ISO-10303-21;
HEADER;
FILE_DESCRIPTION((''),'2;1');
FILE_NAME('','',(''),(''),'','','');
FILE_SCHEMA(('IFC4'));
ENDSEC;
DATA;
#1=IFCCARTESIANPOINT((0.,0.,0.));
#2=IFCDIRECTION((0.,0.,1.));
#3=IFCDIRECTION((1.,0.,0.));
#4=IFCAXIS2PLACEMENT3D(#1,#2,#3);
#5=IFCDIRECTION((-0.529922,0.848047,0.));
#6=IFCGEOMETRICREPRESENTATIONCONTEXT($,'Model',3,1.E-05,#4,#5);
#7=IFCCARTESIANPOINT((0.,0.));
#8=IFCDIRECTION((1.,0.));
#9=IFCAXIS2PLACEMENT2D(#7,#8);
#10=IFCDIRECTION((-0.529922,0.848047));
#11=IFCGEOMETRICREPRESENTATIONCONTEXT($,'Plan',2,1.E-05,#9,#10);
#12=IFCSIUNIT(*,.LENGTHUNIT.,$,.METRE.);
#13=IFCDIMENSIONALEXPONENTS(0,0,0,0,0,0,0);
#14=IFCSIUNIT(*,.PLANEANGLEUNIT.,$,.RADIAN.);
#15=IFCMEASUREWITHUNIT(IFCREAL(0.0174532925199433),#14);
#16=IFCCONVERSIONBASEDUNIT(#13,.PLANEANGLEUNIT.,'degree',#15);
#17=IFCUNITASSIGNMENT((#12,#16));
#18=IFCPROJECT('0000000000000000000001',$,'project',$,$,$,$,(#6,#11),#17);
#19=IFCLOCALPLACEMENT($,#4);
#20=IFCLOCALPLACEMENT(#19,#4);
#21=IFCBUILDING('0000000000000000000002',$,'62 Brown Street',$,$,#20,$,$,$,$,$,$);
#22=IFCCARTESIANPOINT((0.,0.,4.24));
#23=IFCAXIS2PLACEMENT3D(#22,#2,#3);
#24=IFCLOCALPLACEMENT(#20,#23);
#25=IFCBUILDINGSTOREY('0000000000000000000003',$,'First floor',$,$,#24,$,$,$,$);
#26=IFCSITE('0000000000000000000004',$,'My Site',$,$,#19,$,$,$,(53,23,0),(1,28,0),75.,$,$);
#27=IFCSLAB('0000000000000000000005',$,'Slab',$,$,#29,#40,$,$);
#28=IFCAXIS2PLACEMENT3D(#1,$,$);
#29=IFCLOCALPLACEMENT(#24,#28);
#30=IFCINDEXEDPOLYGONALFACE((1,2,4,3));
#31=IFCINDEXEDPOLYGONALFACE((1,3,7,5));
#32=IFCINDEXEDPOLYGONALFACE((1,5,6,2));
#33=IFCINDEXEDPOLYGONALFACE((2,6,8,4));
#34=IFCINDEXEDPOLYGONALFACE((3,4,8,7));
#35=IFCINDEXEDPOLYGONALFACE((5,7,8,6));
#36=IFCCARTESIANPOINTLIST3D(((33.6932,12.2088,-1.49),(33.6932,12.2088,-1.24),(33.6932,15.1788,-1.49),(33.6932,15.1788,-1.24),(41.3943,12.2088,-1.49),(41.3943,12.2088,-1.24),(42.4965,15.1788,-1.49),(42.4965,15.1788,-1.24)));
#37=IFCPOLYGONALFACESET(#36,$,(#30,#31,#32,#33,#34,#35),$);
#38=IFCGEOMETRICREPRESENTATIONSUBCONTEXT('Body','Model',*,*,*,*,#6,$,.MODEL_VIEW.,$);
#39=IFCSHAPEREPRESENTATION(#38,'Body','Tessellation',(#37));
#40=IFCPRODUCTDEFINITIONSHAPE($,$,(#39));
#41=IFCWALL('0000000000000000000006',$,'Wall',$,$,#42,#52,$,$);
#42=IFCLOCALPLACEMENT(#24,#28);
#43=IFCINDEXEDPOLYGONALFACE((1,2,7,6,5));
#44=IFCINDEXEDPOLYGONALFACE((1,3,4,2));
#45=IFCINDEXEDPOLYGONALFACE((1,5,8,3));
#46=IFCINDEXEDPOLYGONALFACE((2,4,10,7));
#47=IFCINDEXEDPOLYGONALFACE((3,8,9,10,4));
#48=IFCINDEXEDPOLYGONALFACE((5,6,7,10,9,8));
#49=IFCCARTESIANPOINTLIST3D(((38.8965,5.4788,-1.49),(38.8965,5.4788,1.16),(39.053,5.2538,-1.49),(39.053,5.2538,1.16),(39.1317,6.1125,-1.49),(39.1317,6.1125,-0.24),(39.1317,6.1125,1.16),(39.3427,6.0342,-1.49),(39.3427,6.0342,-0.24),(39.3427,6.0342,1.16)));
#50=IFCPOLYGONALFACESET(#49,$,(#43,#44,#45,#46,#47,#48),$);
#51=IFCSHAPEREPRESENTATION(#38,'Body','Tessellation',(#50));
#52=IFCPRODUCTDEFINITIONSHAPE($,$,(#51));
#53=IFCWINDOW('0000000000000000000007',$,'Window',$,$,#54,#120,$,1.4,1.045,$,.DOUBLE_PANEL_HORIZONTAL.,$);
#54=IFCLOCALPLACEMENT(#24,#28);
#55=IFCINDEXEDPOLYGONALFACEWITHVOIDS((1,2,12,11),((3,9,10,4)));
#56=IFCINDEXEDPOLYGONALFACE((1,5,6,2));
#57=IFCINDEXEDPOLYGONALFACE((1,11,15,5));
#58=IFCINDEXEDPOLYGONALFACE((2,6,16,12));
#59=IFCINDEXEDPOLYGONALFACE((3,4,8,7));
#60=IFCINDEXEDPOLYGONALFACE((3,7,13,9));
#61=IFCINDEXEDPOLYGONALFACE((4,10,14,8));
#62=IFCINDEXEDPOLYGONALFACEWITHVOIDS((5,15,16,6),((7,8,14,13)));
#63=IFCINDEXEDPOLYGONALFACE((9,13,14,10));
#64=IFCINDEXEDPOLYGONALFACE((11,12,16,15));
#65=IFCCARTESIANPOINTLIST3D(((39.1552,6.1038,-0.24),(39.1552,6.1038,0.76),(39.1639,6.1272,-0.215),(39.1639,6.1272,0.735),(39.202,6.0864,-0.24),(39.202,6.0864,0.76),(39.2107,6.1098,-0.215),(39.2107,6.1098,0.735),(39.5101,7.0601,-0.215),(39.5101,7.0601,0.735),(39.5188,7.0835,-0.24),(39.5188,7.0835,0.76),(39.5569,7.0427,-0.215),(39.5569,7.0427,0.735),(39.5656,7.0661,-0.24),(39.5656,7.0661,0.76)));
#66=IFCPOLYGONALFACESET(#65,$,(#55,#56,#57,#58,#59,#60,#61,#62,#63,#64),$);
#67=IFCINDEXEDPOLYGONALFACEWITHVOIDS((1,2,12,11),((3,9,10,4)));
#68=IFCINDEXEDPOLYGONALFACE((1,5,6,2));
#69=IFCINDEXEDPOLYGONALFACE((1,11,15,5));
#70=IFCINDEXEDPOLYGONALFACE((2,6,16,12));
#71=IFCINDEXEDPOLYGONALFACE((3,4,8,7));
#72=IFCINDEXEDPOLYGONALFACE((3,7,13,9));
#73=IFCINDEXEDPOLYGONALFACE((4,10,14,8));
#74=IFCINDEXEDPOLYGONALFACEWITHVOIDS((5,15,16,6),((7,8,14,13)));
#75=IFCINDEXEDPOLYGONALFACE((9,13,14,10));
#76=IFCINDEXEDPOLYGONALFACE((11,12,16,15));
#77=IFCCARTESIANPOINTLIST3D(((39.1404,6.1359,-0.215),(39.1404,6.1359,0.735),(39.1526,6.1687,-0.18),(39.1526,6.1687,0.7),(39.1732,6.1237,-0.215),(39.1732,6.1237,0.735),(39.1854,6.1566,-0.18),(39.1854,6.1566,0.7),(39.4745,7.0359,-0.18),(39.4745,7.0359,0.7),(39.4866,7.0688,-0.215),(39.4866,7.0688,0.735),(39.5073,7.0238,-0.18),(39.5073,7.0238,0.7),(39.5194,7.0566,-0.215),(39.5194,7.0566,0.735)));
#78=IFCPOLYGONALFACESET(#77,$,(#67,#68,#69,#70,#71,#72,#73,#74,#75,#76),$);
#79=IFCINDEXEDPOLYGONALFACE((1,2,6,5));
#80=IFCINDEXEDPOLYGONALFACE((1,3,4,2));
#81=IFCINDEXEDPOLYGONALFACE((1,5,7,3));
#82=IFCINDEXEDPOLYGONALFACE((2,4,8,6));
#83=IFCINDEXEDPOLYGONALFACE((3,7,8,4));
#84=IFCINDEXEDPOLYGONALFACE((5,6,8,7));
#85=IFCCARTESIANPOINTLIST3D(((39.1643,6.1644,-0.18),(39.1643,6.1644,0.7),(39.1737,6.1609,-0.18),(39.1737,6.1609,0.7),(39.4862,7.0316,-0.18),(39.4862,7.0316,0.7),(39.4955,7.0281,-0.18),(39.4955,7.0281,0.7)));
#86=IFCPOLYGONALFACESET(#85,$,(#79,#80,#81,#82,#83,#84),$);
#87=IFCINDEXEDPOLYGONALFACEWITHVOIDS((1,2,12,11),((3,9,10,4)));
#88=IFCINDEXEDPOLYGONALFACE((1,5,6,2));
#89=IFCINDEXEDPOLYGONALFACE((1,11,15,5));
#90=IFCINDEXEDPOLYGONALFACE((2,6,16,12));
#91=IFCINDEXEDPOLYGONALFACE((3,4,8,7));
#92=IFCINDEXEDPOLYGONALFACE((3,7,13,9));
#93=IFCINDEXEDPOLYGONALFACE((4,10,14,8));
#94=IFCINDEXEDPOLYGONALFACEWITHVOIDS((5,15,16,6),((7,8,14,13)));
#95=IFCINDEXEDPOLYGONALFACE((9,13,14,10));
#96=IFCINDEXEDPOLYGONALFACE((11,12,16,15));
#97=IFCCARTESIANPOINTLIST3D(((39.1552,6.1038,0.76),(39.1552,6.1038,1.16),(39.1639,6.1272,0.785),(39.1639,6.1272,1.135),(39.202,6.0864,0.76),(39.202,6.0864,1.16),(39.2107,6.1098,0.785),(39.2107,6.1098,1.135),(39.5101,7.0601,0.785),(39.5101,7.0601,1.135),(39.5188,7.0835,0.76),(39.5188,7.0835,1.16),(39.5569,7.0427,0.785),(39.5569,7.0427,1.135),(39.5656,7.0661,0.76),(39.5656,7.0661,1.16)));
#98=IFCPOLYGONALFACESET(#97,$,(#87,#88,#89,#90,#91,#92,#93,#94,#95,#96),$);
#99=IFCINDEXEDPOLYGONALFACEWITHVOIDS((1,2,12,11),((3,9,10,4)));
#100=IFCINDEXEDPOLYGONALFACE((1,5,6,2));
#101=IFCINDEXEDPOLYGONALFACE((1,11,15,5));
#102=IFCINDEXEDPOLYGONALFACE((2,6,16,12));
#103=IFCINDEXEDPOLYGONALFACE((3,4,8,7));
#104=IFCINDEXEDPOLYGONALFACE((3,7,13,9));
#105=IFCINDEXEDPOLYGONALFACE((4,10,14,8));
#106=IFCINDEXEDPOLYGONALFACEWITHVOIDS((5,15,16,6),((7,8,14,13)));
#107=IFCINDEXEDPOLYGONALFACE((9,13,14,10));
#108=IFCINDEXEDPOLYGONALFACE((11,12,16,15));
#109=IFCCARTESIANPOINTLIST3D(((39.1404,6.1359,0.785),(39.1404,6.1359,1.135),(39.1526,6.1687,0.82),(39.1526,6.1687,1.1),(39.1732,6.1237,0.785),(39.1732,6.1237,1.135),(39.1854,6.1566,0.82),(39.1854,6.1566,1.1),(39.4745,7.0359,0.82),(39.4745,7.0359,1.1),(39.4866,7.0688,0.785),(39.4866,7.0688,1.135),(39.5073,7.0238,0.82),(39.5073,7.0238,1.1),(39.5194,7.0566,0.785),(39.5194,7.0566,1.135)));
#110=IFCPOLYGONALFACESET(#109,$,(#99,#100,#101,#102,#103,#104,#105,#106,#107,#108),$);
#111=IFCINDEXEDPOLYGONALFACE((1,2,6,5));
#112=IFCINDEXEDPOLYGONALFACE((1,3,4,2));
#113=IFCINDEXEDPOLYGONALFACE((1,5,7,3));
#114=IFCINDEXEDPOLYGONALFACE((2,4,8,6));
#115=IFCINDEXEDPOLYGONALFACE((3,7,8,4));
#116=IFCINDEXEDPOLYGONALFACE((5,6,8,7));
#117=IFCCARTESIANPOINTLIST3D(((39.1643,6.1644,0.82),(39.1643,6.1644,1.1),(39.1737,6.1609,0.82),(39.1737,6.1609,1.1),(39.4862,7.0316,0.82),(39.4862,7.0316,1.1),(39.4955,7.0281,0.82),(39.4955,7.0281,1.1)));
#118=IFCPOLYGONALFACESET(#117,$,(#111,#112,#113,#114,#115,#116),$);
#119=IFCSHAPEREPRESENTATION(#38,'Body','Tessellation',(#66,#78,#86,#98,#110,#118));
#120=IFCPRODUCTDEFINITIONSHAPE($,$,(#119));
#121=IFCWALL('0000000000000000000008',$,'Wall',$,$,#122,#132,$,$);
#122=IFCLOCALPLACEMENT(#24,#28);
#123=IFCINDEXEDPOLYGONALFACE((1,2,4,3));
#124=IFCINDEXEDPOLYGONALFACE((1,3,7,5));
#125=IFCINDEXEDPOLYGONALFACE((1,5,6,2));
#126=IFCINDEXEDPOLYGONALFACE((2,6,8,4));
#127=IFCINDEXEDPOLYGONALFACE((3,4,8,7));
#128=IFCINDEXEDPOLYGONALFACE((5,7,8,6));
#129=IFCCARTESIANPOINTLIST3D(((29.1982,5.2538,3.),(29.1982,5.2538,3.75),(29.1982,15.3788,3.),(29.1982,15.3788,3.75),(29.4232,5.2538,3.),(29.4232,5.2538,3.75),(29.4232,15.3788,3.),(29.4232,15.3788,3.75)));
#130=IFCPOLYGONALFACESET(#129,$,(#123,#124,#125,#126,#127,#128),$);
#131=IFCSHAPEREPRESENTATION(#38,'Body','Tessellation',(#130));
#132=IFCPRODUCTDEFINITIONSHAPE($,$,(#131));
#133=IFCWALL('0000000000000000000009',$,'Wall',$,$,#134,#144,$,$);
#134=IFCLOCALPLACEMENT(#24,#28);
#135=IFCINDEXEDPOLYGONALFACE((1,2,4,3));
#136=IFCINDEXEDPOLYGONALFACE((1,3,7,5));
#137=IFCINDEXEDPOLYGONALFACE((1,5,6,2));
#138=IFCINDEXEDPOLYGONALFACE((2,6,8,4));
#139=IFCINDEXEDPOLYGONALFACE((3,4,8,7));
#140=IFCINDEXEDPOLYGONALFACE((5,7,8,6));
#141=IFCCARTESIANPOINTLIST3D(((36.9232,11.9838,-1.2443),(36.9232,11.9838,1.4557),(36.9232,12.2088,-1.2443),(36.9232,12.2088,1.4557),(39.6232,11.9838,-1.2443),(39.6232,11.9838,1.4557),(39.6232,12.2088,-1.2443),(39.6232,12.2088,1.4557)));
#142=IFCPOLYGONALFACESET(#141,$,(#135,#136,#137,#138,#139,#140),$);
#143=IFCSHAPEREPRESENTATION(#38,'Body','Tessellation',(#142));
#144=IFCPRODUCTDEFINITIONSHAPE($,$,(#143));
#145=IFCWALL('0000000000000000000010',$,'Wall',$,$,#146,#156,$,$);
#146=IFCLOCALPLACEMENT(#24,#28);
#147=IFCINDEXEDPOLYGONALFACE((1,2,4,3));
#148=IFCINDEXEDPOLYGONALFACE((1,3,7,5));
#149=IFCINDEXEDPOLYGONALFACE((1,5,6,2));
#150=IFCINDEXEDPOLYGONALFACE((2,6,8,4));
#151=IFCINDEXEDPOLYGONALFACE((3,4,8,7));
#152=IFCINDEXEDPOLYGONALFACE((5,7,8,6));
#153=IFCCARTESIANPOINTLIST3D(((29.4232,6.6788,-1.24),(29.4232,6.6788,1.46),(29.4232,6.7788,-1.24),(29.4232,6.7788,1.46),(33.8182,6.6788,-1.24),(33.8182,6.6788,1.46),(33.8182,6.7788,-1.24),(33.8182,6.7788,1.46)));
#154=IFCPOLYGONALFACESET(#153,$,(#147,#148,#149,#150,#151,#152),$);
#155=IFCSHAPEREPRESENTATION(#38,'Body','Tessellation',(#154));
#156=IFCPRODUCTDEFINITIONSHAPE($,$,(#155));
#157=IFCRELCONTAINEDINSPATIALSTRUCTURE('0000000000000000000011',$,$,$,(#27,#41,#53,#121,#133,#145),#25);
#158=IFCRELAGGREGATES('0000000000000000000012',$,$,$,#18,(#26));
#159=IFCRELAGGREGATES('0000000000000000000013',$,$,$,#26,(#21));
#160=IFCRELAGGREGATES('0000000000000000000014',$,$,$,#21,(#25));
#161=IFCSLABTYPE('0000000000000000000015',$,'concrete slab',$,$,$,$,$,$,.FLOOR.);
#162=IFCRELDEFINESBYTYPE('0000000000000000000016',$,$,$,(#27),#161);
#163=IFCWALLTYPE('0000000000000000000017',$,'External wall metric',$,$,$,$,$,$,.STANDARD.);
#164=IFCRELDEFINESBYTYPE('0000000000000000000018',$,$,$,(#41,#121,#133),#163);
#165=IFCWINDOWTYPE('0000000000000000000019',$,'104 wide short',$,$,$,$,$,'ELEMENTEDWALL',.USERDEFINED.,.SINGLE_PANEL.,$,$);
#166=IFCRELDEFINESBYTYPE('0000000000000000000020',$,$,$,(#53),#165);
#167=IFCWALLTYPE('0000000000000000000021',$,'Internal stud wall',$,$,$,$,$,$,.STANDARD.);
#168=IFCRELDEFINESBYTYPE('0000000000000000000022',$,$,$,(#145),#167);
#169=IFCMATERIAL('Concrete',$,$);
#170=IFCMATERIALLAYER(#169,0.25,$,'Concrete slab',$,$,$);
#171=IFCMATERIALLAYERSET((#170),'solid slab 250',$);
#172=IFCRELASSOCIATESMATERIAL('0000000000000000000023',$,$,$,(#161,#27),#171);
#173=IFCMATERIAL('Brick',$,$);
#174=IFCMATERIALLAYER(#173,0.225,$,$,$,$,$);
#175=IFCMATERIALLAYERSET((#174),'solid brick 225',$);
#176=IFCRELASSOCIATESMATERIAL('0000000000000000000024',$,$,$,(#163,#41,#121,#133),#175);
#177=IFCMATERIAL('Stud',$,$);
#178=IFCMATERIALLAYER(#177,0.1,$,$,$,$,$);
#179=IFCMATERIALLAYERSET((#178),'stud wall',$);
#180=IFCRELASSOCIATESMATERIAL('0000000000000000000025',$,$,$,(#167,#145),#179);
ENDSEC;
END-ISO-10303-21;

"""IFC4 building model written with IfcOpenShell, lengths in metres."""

from ifc_helpers import new_model, entity, si_unit, converted_unit, direction, frame, origin_with_axes, origin_2d_with_axis, place, context, subcontext, project, spatial, line, indexed_curve, outline, extrude, clip, halfspace, shape, source, transform, mapped, material, layer, layer_set, layer_usage, type_object, type_shapes, element, fill, save


model = new_model("IFC4")

# Units and contexts
model_context = context("Model", 3, precision=1e-05, world=origin_with_axes(), true_north=direction((-0.529922, 0.848047, 0.0)))
plan_context = context("Plan", 2, precision=1e-05, world=origin_2d_with_axis(), true_north=direction((-0.529922, 0.848047)))
body_context_1 = subcontext(model_context, "Body", "Model", "MODEL_VIEW")
body_context_2 = subcontext(plan_context, "Body", "Plan", "PLAN_VIEW")
ifc_project = project(units=[si_unit("LENGTHUNIT", "METRE"), converted_unit("PLANEANGLEUNIT", "degree", entity("IfcReal", 0.0174532925199433), si_unit("PLANEANGLEUNIT", "RADIAN"), dimensions=[0, 0, 0, 0, 0, 0, 0])], contexts=[model_context, plan_context])

# Site, building, storey
site_placement = place(None, origin_with_axes())
site = spatial("IfcSite", under=ifc_project, at=site_placement, Name="My Site", RefLatitude=(53, 23, 0), RefLongitude=(1, 28, 0), RefElevation=75.0)
building_placement = place(site_placement, origin_with_axes())
building = spatial("IfcBuilding", under=site, at=building_placement, Name="62 Brown Street")
storey_placement = place(building_placement, frame((0.0, 0.0, 4.24), z_axis=(0.0, 0.0, 1.0), x_axis=(1.0, 0.0, 0.0)))
storey = spatial("IfcBuildingStorey", under=building, at=storey_placement, Name="First floor")

# Slab
ifc_material_1 = material(Name="Concrete")
ifc_layer_1 = layer(ifc_material_1, 0.25, Name="Concrete slab")
ifc_layer_set_1 = layer_set([ifc_layer_1], Name="solid slab 250")
ifc_layer_usage_1 = layer_usage(ifc_layer_set_1, "AXIS3", "POSITIVE", 0.0)
slab_type = type_object("IfcSlabType", Name="concrete slab", PredefinedType="FLOOR", material=ifc_layer_set_1)
slab_placement = place(storey_placement, frame((33.6932, 12.2088, -1.49), z_axis=(0.0, 0.0, 1.0), x_axis=(1.0, 0.0, 0.0)))
element("IfcSlab", 1, at=slab_placement, inside=storey, type_object=slab_type, material=ifc_layer_usage_1, Name="Slab", context=body_context_1, shape_type="SweptSolid", body=[
    extrude(outline(indexed_curve([(8.8033, 2.97), (7.7011, 0.0), (0.0, 0.0), (0.0, 2.97)], segments=[line(4, 1), line(1, 2), line(2, 3), line(3, 4)], self_intersect=False)), None, (0.0, 0.0, 1.0), 0.25),
])

# Shared definitions
ifc_material_2 = material(Name="Brick")
ifc_layer_2 = layer(ifc_material_2, 0.225)
ifc_layer_set_2 = layer_set([ifc_layer_2], Name="solid brick 225")
wall_type_1 = type_object("IfcWallType", Name="External wall metric", PredefinedType="STANDARD", material=ifc_layer_set_2)

# Wall, opening, window
ifc_layer_usage_2 = layer_usage(ifc_layer_set_2, "AXIS2", "POSITIVE", 0.0)
wall_1_placement = place(storey_placement, frame((39.024, 5.1755, -1.49), z_axis=(0.0, 0.0, 1.0), x_axis=(0.347944, 0.937515, 0.0)))
wall_1 = element("IfcWall", 2, at=wall_1_placement, inside=storey, type_object=wall_type_1, material=ifc_layer_usage_2, Name="Wall", context=body_context_1, shape_type="Clipping", body=[
    clip(extrude(outline(indexed_curve([(0.0, 0.0), (0.0, 0.225), (0.9159, 0.225), (0.9159, 0.0), (0.0, 0.0)], self_intersect=False)), origin_with_axes(), (0.0, 0.0, 1.0), 2.65), halfspace(frame((0.0835, 0.0, -2.75), z_axis=(-0.596248, 0.414701, 0.0), x_axis=(0.156491, 0.224999, 0.0)), False)),
])
shared_shape_1 = source(origin_with_axes(), body_context_1, "Body", "SweptSolid", [
    extrude(outline(indexed_curve([(0.0, 0.0), (1.045, 0.0), (1.045, 1.4), (0.0, 1.4)], segments=[line(1, 2, 3, 4, 1)])), frame((0.0, -0.1, 0.0), z_axis=(0.0, -1.0, 0.0), x_axis=(1.0, 0.0, 0.0)), (0.0, 0.0, -1.0), 0.425),
])
opening_1_placement = place(wall_1_placement, frame((0.9159, 0.0, 1.25), z_axis=(0.0, 0.0, 1.0), x_axis=(1.0, 0.0, 0.0)))
opening_1 = element("IfcOpeningElement", 3, at=opening_1_placement, cuts=wall_1, PredefinedType="OPENING", context=body_context_1, shape_type="MappedRepresentation", body=[
    mapped(shared_shape_1, transform((0.0, 0.0, 0.0), x_axis=(1.0, 0.0, 0.0), y_axis=(0.0, 1.0, 0.0), z_axis=(0.0, 0.0, 1.0), scale=1.0)),
])
window_type_1 = type_object("IfcWindowType", Name="104 wide short", ElementType="ELEMENTEDWALL", PartitioningType="SINGLE_PANEL", PredefinedType="USERDEFINED")
shared_shape_2 = source(origin_with_axes(), body_context_1, "Body", "SweptSolid", [
    extrude(outline(indexed_curve([(0.0, 0.0), (1.045, 0.0), (1.045, 1.0), (0.0, 1.0)], segments=[line(1, 2, 3, 4, 1)]), holes=[indexed_curve([(0.025, 0.025), (1.02, 0.025), (1.02, 0.975), (0.025, 0.975)], segments=[line(1, 2, 3, 4, 1)])]), frame((0.0, 0.15, 0.0), z_axis=(0.0, -1.0, 0.0), x_axis=(1.0, 0.0, 0.0)), (0.0, 0.0, -1.0), 0.05),
    extrude(outline(indexed_curve([(0.0, 0.0), (0.995, 0.0), (0.995, 0.95), (0.0, 0.95)], segments=[line(1, 2, 3, 4, 1)]), holes=[indexed_curve([(0.035, 0.035), (0.96, 0.035), (0.96, 0.915), (0.035, 0.915)], segments=[line(1, 2, 3, 4, 1)])]), frame((0.025, 0.19, 0.025), z_axis=(0.0, -1.0, 0.0), x_axis=(1.0, 0.0, 0.0)), (0.0, 0.0, -1.0), 0.035),
    extrude(outline(indexed_curve([(0.035, 0.035), (0.96, 0.035), (0.96, 0.915), (0.035, 0.915)], segments=[line(1, 2, 3, 4, 1)])), frame((0.025, 0.2025, 0.025), z_axis=(0.0, -1.0, 0.0), x_axis=(1.0, 0.0, 0.0)), (0.0, 0.0, -1.0), 0.01),
    extrude(outline(indexed_curve([(0.0, 0.0), (1.045, 0.0), (1.045, 0.4), (0.0, 0.4)], segments=[line(1, 2, 3, 4, 1)]), holes=[indexed_curve([(0.025, 0.025), (1.02, 0.025), (1.02, 0.375), (0.025, 0.375)], segments=[line(1, 2, 3, 4, 1)])]), frame((0.0, 0.15, 1.0), z_axis=(0.0, -1.0, 0.0), x_axis=(1.0, 0.0, 0.0)), (0.0, 0.0, -1.0), 0.05),
    extrude(outline(indexed_curve([(0.0, 0.0), (0.995, 0.0), (0.995, 0.35), (0.0, 0.35)], segments=[line(1, 2, 3, 4, 1)]), holes=[indexed_curve([(0.035, 0.035), (0.96, 0.035), (0.96, 0.315), (0.035, 0.315)], segments=[line(1, 2, 3, 4, 1)])]), frame((0.025, 0.19, 1.025), z_axis=(0.0, -1.0, 0.0), x_axis=(1.0, 0.0, 0.0)), (0.0, 0.0, -1.0), 0.035),
    extrude(outline(indexed_curve([(0.035, 0.035), (0.96, 0.035), (0.96, 0.315), (0.035, 0.315)], segments=[line(1, 2, 3, 4, 1)])), frame((0.025, 0.2025, 1.025), z_axis=(0.0, -1.0, 0.0), x_axis=(1.0, 0.0, 0.0)), (0.0, 0.0, -1.0), 0.01),
])
shared_shape_3 = source(origin_with_axes(), body_context_2, "Body", "Curve2D", [
    entity("IfcIndexedPolyCurve", entity("IfcCartesianPointList2D", [[0.025, 0.15], [1.02, 0.15]])),
    entity("IfcIndexedPolyCurve", entity("IfcCartesianPointList2D", [[0.0, 0.2], [0.025, 0.2], [0.025, 0.15], [0.0, 0.15]]), [entity("IfcLineIndex", [1, 2, 3, 4, 1])]),
    entity("IfcIndexedPolyCurve", entity("IfcCartesianPointList2D", [[1.045, 0.2], [1.02, 0.2], [1.02, 0.15], [1.045, 0.15]]), [entity("IfcLineIndex", [1, 2, 3, 4, 1])]),
    entity("IfcIndexedPolyCurve", entity("IfcCartesianPointList2D", [[0.025, 0.19], [0.06, 0.19], [0.06, 0.225], [0.025, 0.225]]), [entity("IfcLineIndex", [1, 2, 3, 4, 1])]),
    entity("IfcIndexedPolyCurve", entity("IfcCartesianPointList2D", [[1.02, 0.19], [0.985, 0.19], [0.985, 0.225], [1.02, 0.225]]), [entity("IfcLineIndex", [1, 2, 3, 4, 1])]),
    entity("IfcIndexedPolyCurve", entity("IfcCartesianPointList2D", [[0.06, 0.19], [0.985, 0.19]])),
    entity("IfcIndexedPolyCurve", entity("IfcCartesianPointList2D", [[0.06, 0.225], [0.985, 0.225]])),
    entity("IfcIndexedPolyCurve", entity("IfcCartesianPointList2D", [[0.06, 0.2075], [0.985, 0.2075]])),
])
type_shapes(window_type_1, [shared_shape_2, shared_shape_3])
window_1_placement = place(opening_1_placement, frame((0.0, 0.0, 0.0), z_axis=(0.0, 0.0, 1.0), x_axis=(1.0, 0.0, 0.0)))
window_1 = element("IfcWindow", 4, at=window_1_placement, inside=storey, type_object=window_type_1, Name="Window", OverallHeight=1.4, OverallWidth=1.045, PartitioningType="DOUBLE_PANEL_HORIZONTAL", shapes=[
    shape(body_context_1, "Body", "MappedRepresentation", [mapped(shared_shape_2, transform((0.0, 0.0, 0.0), x_axis=(1.0, 0.0, 0.0), y_axis=(0.0, 1.0, 0.0), z_axis=(0.0, 0.0, 1.0), scale=1.0))]),
    shape(body_context_2, "Body", "MappedRepresentation", [mapped(shared_shape_3, transform((0.0, 0.0, 0.0), x_axis=(1.0, 0.0, 0.0), y_axis=(0.0, 1.0, 0.0), z_axis=(0.0, 0.0, 1.0), scale=1.0))]),
])
fill(opening_1, window_1)

# Walls
ifc_layer_usage_3 = layer_usage(ifc_layer_set_2, "AXIS2", "POSITIVE", 0.0)
wall_2_placement = place(storey_placement, frame((29.4232, 5.2538, 3.0), z_axis=(0.0, 0.0, 1.0), x_axis=(0.0, 1.0, 0.0)))
element("IfcWall", 5, at=wall_2_placement, inside=storey, type_object=wall_type_1, material=ifc_layer_usage_3, Name="Wall", context=body_context_1, shape_type="SweptSolid", body=[
    extrude(outline(indexed_curve([(0.0, 0.0), (0.0, 0.225), (10.125, 0.225), (10.125, 0.0), (0.0, 0.0)], self_intersect=False)), origin_with_axes(), (0.0, 0.0, 1.0), 0.75),
])
ifc_layer_usage_4 = layer_usage(ifc_layer_set_2, "AXIS2", "POSITIVE", 0.0)
wall_3_placement = place(storey_placement, frame((36.9232, 11.9838, -1.2443), z_axis=(0.0, 0.0, 1.0), x_axis=(1.0, 0.0, 0.0)))
element("IfcWall", 6, at=wall_3_placement, inside=storey, type_object=wall_type_1, material=ifc_layer_usage_4, Name="Wall", context=body_context_1, shape_type="SweptSolid", body=[
    extrude(outline(indexed_curve([(0.0, 0.0), (0.0, 0.225), (2.7, 0.225), (2.7, 0.0), (0.0, 0.0)], self_intersect=False)), origin_with_axes(), (0.0, 0.0, 1.0), 2.7),
])

# Shared definitions
ifc_material_3 = material(Name="Stud")
ifc_layer_3 = layer(ifc_material_3, 0.1)
ifc_layer_set_3 = layer_set([ifc_layer_3], Name="stud wall")
wall_type_2 = type_object("IfcWallType", Name="Internal stud wall", PredefinedType="STANDARD", material=ifc_layer_set_3)

# Wall
ifc_layer_usage_5 = layer_usage(ifc_layer_set_3, "AXIS2", "POSITIVE", 0.0)
wall_4_placement = place(storey_placement, frame((33.8182, 6.7788, -1.24), z_axis=(0.0, 0.0, 1.0), x_axis=(-1.0, 0.000001, 0.0)))
element("IfcWall", 7, at=wall_4_placement, inside=storey, type_object=wall_type_2, material=ifc_layer_usage_5, Name="Wall", context=body_context_1, shape_type="SweptSolid", body=[
    extrude(outline(indexed_curve([(0.0, 0.0), (0.0, 0.1), (4.395, 0.1), (4.395, 0.0), (0.0, 0.0)], self_intersect=False)), origin_with_axes(), (0.0, 0.0, 1.0), 2.7),
])

save(model, "model.ifc")
